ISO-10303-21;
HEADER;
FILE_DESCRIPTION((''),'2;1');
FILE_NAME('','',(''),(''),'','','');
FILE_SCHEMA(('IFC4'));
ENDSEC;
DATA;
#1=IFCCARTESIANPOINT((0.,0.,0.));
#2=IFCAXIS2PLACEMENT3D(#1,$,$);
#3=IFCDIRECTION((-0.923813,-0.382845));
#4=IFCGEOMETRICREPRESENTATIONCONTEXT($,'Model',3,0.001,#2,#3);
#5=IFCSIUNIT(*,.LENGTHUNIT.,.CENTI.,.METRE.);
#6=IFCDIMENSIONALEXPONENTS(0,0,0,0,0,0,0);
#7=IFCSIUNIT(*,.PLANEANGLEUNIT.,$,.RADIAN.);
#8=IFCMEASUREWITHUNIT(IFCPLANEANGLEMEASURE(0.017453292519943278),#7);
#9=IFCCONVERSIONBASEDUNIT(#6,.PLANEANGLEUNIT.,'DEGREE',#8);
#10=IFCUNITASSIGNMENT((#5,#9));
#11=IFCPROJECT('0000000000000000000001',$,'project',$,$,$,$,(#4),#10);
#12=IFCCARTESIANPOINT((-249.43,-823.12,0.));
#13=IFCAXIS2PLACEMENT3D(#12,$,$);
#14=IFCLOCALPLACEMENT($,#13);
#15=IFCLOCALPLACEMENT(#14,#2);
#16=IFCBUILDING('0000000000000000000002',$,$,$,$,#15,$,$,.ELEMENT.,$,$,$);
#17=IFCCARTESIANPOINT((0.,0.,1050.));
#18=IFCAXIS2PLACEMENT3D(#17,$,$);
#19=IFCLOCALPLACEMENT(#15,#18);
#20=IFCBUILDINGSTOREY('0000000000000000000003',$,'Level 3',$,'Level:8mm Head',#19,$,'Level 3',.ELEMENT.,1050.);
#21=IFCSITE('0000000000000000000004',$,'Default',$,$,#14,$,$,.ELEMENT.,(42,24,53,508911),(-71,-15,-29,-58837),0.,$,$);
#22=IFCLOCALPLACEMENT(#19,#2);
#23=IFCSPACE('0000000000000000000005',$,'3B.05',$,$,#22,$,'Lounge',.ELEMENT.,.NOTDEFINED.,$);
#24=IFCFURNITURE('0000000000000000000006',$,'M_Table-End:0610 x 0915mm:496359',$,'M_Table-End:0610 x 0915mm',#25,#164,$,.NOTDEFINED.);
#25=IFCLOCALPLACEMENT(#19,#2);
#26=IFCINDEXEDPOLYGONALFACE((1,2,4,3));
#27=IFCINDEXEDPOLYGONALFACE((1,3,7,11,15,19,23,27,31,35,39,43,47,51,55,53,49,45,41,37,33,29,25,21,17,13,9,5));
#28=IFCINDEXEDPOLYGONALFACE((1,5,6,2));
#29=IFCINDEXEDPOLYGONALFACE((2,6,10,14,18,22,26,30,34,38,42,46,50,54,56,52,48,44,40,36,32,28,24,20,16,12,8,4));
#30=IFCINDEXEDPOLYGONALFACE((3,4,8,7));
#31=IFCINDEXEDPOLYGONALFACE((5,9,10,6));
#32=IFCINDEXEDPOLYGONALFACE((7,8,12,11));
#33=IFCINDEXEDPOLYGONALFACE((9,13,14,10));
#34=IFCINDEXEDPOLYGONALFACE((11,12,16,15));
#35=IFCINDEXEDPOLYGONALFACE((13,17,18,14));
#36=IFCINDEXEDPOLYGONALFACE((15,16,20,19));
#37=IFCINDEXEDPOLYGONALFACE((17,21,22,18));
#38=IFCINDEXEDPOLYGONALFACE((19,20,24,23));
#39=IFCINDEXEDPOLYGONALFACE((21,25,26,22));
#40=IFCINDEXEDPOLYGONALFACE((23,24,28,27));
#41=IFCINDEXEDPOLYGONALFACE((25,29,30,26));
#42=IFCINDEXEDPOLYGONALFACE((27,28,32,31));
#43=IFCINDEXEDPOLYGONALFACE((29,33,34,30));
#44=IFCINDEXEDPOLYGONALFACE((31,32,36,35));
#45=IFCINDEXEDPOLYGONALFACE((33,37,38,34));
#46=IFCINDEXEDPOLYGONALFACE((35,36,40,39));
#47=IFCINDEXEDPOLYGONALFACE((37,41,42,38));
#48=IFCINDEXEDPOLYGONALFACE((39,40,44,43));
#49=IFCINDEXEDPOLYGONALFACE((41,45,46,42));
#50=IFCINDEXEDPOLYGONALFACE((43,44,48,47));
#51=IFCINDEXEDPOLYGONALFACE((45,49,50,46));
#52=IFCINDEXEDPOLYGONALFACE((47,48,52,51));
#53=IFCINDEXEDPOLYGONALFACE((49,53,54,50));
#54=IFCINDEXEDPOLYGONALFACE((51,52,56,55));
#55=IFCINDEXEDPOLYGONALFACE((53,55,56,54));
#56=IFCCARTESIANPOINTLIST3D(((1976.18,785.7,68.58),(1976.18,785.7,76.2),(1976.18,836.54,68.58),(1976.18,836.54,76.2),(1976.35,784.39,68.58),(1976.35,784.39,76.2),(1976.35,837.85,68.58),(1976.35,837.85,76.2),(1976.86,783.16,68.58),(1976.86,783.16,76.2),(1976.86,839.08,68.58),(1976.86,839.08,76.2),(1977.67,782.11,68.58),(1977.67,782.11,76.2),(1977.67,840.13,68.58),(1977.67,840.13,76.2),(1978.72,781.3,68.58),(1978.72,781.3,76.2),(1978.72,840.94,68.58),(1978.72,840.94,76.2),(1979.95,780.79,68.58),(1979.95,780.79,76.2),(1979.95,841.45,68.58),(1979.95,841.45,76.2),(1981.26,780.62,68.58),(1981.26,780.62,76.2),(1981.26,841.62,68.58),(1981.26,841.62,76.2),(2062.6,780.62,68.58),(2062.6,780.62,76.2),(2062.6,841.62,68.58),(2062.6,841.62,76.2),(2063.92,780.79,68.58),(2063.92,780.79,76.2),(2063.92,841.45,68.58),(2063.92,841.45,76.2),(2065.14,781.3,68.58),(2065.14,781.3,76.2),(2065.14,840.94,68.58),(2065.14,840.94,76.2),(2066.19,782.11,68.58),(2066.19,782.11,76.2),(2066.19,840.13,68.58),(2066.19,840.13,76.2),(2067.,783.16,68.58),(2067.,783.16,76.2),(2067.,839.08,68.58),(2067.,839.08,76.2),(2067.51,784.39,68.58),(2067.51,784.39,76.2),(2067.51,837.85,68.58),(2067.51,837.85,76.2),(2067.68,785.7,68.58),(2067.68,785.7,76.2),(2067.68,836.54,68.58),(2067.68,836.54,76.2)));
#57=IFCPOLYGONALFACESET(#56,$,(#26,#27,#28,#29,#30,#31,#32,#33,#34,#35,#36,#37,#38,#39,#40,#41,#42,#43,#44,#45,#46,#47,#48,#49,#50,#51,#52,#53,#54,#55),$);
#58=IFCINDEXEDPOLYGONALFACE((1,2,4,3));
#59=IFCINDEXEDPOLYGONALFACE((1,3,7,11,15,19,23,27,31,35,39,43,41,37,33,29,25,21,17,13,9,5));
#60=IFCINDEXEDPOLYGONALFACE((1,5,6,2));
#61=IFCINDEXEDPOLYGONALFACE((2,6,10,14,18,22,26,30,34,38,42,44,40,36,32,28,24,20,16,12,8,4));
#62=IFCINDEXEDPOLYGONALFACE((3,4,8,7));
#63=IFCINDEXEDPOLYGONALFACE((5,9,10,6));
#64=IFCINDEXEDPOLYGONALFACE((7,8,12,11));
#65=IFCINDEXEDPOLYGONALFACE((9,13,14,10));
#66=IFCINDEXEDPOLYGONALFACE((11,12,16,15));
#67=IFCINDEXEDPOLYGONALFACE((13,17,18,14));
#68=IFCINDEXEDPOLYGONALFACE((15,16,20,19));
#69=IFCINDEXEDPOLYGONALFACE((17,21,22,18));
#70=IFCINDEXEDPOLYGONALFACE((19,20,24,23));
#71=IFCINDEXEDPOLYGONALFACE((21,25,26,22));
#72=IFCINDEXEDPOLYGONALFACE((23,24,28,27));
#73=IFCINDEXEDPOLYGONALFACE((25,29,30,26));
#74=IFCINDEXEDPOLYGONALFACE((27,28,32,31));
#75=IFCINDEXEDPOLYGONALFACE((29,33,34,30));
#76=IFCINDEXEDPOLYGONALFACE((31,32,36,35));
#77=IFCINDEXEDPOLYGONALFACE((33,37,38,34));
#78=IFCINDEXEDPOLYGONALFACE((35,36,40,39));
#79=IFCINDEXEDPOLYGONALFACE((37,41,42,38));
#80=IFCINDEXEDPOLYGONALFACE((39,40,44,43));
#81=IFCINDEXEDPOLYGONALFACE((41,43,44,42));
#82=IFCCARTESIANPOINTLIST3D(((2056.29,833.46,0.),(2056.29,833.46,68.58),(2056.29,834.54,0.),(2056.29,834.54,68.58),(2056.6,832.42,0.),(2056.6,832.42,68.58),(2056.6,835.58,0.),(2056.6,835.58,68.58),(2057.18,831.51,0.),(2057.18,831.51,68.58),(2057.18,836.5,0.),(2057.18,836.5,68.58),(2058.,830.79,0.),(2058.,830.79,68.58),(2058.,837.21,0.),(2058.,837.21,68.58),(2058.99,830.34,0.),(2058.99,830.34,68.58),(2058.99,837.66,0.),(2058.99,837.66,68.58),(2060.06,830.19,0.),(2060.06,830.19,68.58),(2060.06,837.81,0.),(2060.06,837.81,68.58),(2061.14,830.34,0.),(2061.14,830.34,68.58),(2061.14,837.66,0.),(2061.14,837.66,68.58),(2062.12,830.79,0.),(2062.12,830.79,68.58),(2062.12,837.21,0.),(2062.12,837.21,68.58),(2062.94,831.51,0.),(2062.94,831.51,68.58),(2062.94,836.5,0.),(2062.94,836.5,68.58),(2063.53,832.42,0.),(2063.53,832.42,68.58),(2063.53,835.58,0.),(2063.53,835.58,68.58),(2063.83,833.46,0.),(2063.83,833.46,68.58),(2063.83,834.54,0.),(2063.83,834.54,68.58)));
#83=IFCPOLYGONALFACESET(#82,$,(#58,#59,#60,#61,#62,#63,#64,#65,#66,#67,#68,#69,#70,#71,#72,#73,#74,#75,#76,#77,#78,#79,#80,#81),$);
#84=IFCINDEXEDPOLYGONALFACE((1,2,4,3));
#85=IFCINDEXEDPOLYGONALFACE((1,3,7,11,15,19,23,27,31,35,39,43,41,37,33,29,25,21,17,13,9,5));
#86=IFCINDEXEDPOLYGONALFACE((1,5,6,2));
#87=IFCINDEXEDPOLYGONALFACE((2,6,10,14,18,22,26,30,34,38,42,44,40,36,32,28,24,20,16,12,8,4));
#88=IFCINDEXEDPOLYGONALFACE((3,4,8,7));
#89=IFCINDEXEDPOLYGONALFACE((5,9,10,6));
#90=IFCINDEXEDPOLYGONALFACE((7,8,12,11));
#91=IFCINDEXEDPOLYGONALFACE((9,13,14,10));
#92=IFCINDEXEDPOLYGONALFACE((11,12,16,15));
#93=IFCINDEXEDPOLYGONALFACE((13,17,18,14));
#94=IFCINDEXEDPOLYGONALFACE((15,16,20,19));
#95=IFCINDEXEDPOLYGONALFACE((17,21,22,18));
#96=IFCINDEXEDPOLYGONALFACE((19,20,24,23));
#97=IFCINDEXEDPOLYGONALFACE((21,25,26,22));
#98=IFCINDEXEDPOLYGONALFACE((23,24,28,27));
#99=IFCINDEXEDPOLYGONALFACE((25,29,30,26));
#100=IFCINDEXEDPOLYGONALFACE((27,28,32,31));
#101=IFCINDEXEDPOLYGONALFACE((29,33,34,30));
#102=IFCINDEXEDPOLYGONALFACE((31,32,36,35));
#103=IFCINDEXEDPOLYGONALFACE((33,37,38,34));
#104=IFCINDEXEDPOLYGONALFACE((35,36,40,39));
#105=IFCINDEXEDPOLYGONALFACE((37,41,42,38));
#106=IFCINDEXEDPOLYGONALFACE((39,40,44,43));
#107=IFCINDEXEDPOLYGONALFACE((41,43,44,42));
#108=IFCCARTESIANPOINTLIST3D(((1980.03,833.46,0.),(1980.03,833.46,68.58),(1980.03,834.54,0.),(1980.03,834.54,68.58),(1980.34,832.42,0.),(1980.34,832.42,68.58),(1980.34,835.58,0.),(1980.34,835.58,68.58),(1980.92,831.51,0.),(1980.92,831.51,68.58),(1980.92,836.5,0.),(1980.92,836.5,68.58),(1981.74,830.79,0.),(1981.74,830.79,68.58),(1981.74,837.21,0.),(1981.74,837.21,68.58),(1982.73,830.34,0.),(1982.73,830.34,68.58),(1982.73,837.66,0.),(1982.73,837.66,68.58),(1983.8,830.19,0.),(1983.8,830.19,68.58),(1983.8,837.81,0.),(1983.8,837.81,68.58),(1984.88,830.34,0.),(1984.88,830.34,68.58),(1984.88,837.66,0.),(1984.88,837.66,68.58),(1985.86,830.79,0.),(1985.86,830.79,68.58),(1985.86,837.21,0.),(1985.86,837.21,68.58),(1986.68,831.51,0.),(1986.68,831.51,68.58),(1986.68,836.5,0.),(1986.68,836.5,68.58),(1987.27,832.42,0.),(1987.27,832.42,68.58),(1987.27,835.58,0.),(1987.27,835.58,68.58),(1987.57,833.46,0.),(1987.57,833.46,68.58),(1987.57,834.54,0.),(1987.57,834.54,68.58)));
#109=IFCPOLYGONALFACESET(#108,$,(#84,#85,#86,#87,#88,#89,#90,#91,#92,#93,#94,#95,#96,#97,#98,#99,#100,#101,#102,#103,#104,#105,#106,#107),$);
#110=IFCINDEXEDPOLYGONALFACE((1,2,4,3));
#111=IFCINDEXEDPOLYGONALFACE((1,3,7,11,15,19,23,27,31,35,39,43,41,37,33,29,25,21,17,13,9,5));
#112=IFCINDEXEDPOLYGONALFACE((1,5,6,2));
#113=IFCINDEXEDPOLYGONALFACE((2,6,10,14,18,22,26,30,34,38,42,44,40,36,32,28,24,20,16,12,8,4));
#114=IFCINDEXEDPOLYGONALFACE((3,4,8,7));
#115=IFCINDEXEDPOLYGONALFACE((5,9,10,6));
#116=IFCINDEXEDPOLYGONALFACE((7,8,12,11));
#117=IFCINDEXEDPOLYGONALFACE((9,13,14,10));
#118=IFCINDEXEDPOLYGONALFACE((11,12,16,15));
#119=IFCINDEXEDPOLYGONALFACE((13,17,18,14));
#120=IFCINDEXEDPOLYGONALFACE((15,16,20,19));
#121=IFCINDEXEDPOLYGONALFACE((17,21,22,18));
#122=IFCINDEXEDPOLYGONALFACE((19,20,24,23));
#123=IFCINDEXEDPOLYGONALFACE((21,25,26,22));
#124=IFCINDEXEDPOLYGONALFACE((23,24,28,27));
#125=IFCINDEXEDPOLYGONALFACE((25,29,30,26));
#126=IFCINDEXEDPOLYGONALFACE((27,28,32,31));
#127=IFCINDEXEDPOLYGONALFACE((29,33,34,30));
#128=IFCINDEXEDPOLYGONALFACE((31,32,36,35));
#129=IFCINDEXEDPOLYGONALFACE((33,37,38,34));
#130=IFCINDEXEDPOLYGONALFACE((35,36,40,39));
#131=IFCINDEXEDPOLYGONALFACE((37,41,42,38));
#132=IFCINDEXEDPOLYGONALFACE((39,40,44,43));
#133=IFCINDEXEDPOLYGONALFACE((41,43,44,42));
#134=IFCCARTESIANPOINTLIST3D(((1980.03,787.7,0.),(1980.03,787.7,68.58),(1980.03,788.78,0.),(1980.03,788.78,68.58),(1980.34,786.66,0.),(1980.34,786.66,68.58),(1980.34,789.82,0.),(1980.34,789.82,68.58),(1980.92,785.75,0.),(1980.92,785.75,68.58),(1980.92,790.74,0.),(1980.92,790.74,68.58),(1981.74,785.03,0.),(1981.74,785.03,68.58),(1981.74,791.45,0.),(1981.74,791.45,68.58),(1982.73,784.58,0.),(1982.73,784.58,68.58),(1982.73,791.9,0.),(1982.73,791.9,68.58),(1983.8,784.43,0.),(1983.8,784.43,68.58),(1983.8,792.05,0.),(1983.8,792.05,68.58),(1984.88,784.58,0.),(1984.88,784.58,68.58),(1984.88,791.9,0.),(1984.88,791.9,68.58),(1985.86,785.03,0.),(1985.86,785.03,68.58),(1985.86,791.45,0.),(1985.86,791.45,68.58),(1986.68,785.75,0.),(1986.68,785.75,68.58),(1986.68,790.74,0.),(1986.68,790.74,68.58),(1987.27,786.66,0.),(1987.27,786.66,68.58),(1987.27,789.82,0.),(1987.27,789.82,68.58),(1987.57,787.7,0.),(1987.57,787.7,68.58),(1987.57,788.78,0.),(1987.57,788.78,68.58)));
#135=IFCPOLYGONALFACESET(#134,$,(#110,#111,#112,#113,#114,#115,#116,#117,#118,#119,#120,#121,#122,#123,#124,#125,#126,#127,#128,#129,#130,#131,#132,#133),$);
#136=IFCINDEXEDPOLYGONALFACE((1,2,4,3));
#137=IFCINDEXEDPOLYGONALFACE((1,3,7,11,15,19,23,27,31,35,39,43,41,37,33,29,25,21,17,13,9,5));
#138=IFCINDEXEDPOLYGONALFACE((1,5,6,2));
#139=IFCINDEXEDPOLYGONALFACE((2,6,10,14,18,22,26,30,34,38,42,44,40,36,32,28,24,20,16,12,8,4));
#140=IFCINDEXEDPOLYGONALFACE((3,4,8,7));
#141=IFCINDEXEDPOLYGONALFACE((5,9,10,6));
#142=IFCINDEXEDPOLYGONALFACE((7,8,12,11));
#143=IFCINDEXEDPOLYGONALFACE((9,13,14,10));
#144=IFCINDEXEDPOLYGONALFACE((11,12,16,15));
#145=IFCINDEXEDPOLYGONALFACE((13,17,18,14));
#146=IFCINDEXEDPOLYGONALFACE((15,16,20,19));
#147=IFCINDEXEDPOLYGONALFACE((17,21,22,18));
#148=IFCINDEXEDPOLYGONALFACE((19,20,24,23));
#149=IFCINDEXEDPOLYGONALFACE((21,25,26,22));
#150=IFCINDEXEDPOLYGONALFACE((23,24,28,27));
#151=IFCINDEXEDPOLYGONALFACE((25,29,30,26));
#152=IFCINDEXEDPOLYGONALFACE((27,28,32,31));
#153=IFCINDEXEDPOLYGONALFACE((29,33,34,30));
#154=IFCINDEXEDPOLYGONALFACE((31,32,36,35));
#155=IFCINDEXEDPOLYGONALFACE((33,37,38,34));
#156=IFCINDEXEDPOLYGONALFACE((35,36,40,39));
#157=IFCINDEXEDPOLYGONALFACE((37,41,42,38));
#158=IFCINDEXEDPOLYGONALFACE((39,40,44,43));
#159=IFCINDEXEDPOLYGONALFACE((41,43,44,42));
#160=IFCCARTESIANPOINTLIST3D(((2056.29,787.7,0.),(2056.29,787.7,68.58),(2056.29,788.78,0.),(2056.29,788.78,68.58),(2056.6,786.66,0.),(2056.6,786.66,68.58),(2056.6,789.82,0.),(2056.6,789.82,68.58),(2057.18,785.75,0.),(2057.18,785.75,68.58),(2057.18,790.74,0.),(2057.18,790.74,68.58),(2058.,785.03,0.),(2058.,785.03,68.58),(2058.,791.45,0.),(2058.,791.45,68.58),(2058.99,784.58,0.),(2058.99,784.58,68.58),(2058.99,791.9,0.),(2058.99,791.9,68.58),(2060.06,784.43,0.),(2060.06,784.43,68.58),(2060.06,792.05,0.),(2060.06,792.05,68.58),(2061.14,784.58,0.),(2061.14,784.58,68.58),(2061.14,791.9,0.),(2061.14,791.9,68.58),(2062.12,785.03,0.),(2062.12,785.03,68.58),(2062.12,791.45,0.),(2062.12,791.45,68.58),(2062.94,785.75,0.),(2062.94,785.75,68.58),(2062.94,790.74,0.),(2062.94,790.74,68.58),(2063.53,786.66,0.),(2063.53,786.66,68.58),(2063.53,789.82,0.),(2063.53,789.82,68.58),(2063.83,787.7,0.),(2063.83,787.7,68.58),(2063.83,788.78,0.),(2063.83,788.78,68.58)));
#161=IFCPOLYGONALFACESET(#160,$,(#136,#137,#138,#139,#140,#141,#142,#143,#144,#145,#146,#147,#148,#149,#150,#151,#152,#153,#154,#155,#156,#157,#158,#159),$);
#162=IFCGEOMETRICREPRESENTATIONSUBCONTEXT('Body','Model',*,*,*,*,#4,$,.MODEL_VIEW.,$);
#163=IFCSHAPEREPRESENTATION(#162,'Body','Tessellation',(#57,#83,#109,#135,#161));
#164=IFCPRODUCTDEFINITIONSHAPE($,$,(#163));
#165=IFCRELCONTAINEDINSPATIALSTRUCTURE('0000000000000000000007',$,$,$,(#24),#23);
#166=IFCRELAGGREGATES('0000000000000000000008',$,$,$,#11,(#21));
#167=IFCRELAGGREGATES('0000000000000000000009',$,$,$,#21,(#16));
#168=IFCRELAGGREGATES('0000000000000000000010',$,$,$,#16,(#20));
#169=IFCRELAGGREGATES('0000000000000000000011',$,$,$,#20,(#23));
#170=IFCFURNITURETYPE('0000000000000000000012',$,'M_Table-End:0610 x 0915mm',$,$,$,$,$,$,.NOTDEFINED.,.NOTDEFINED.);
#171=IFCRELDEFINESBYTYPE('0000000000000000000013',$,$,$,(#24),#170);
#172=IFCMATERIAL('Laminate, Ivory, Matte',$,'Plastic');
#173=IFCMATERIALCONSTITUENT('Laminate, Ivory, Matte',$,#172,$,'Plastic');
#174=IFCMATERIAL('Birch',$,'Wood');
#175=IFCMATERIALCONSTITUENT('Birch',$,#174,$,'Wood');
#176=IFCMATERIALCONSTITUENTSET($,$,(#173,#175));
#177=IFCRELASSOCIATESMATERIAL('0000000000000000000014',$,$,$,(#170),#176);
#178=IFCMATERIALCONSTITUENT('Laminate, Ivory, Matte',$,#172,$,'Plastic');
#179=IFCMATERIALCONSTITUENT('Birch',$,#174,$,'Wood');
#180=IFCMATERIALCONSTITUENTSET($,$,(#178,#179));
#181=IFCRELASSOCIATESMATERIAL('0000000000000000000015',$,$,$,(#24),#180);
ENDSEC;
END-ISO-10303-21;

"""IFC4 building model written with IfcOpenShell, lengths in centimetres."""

from ifc_helpers import new_model, entity, si_unit, converted_unit, direction, frame, origin, place, context, subcontext, project, spatial, line, arc, indexed_curve, outline, extrude, source, transform, mapped, material, constituent, constituent_set, type_object, type_shapes, element, save


model = new_model("IFC4")

# Units and contexts
model_context = context("Model", 3, precision=0.001, world=origin(), true_north=direction((-0.923813, -0.382845)))
body_context = subcontext(model_context, "Body", "Model", "MODEL_VIEW")
ifc_project = project(units=[si_unit("LENGTHUNIT", "METRE", prefix="CENTI"), converted_unit("PLANEANGLEUNIT", "DEGREE", entity("IfcPlaneAngleMeasure", 0.017453292519943278), si_unit("PLANEANGLEUNIT", "RADIAN"), dimensions=[0, 0, 0, 0, 0, 0, 0])], contexts=[model_context])

# Site, building, storey
site_placement = place(None, frame((-249.43, -823.12, 0.0)))
site = spatial("IfcSite", under=ifc_project, at=site_placement, Name="Default", CompositionType="ELEMENT", RefLatitude=(42, 24, 53, 508911), RefLongitude=(-71, -15, -29, -58837), RefElevation=0.0)
building_placement = place(site_placement, origin())
building = spatial("IfcBuilding", under=site, at=building_placement, CompositionType="ELEMENT")
storey_placement = place(building_placement, frame((0.0, 0.0, 1050.0)))
storey = spatial("IfcBuildingStorey", under=building, at=storey_placement, Name="Level 3", ObjectType="Level:8mm Head", LongName="Level 3", CompositionType="ELEMENT", Elevation=1050.0)

# Shared definitions
space_1_placement = place(storey_placement, origin())
space_1 = spatial("IfcSpace", under=storey, at=space_1_placement, Name="3B.05", LongName="Lounge", CompositionType="ELEMENT", PredefinedType="NOTDEFINED")

# Furniture
ifc_material_1 = material(Name="Laminate, Ivory, Matte", Category="Plastic")
ifc_constituent_1 = constituent(ifc_material_1, Name="Laminate, Ivory, Matte", Category="Plastic")
ifc_material_2 = material(Name="Birch", Category="Wood")
ifc_constituent_2 = constituent(ifc_material_2, Name="Birch", Category="Wood")
ifc_constituent_set_1 = constituent_set(constituents=[ifc_constituent_1, ifc_constituent_2])
ifc_constituent_3 = constituent(ifc_material_1, Name="Laminate, Ivory, Matte", Category="Plastic")
ifc_constituent_4 = constituent(ifc_material_2, Name="Birch", Category="Wood")
ifc_constituent_set_2 = constituent_set(constituents=[ifc_constituent_3, ifc_constituent_4])
furniture_type_1 = type_object("IfcFurnitureType", Name="M_Table-End:0610 x 0915mm", AssemblyPlace="NOTDEFINED", PredefinedType="NOTDEFINED", material=ifc_constituent_set_2)
shared_shape_1 = source(origin(), body_context, "Body", "SweptSolid", [
    extrude(outline(indexed_curve([(25.42, -45.75), (29.01, -44.26), (30.5, -40.67), (30.5, 40.67), (29.01, 44.26), (25.42, 45.75), (-25.42, 45.75), (-29.01, 44.26), (-30.5, 40.67), (-30.5, -40.67), (-29.01, -44.26), (-25.42, -45.75)], segments=[arc(1, 2, 3), line(3, 4), arc(4, 5, 6), line(6, 7), arc(7, 8, 9), line(9, 10), arc(10, 11, 12), line(12, 1)], self_intersect=False)), frame((30.87, 15.24, -381.42)), (0.0, 0.0, 1.0), 7.62),
    extrude(outline(indexed_curve([(-3.81, 0.0), (0.0, -3.81), (3.81, 0.0), (0.0, 3.81)], segments=[arc(1, 2, 3), arc(3, 4, 1)], self_intersect=False)), frame((53.75, -22.89, -450.0)), (0.0, 0.0, 1.0), 68.58),
    extrude(outline(indexed_curve([(-3.81, 0.0), (0.0, -3.81), (3.81, 0.0), (0.0, 3.81)], segments=[arc(1, 2, 3), arc(3, 4, 1)], self_intersect=False)), frame((53.75, 53.37, -450.0)), (0.0, 0.0, 1.0), 68.58),
    extrude(outline(indexed_curve([(-3.81, 0.0), (0.0, -3.81), (3.81, 0.0), (0.0, 3.81)], segments=[arc(1, 2, 3), arc(3, 4, 1)], self_intersect=False)), frame((7.99, 53.37, -450.0)), (0.0, 0.0, 1.0), 68.58),
    extrude(outline(indexed_curve([(-3.81, 0.0), (0.0, -3.81), (3.81, 0.0), (0.0, 3.81)], segments=[arc(1, 2, 3), arc(3, 4, 1)], self_intersect=False)), frame((7.99, -22.89, -450.0)), (0.0, 0.0, 1.0), 68.58),
])
type_shapes(furniture_type_1, [shared_shape_1])
furniture_1_placement = place(space_1_placement, frame((2037.17, 780.25, 450.0), z_axis=(0.0, 0.0, 1.0), x_axis=(0.0, 1.0, 0.0)))
element("IfcFurniture", 1, at=furniture_1_placement, inside=space_1, type_object=furniture_type_1, material=ifc_constituent_set_1, Name="M_Table-End:0610 x 0915mm:496359", ObjectType="M_Table-End:0610 x 0915mm", PredefinedType="NOTDEFINED", context=body_context, shape_type="MappedRepresentation", body=[
    mapped(shared_shape_1, transform((0.0, 0.0, 0.0), scale=1.0)),
])

save(model, "model.ifc")
